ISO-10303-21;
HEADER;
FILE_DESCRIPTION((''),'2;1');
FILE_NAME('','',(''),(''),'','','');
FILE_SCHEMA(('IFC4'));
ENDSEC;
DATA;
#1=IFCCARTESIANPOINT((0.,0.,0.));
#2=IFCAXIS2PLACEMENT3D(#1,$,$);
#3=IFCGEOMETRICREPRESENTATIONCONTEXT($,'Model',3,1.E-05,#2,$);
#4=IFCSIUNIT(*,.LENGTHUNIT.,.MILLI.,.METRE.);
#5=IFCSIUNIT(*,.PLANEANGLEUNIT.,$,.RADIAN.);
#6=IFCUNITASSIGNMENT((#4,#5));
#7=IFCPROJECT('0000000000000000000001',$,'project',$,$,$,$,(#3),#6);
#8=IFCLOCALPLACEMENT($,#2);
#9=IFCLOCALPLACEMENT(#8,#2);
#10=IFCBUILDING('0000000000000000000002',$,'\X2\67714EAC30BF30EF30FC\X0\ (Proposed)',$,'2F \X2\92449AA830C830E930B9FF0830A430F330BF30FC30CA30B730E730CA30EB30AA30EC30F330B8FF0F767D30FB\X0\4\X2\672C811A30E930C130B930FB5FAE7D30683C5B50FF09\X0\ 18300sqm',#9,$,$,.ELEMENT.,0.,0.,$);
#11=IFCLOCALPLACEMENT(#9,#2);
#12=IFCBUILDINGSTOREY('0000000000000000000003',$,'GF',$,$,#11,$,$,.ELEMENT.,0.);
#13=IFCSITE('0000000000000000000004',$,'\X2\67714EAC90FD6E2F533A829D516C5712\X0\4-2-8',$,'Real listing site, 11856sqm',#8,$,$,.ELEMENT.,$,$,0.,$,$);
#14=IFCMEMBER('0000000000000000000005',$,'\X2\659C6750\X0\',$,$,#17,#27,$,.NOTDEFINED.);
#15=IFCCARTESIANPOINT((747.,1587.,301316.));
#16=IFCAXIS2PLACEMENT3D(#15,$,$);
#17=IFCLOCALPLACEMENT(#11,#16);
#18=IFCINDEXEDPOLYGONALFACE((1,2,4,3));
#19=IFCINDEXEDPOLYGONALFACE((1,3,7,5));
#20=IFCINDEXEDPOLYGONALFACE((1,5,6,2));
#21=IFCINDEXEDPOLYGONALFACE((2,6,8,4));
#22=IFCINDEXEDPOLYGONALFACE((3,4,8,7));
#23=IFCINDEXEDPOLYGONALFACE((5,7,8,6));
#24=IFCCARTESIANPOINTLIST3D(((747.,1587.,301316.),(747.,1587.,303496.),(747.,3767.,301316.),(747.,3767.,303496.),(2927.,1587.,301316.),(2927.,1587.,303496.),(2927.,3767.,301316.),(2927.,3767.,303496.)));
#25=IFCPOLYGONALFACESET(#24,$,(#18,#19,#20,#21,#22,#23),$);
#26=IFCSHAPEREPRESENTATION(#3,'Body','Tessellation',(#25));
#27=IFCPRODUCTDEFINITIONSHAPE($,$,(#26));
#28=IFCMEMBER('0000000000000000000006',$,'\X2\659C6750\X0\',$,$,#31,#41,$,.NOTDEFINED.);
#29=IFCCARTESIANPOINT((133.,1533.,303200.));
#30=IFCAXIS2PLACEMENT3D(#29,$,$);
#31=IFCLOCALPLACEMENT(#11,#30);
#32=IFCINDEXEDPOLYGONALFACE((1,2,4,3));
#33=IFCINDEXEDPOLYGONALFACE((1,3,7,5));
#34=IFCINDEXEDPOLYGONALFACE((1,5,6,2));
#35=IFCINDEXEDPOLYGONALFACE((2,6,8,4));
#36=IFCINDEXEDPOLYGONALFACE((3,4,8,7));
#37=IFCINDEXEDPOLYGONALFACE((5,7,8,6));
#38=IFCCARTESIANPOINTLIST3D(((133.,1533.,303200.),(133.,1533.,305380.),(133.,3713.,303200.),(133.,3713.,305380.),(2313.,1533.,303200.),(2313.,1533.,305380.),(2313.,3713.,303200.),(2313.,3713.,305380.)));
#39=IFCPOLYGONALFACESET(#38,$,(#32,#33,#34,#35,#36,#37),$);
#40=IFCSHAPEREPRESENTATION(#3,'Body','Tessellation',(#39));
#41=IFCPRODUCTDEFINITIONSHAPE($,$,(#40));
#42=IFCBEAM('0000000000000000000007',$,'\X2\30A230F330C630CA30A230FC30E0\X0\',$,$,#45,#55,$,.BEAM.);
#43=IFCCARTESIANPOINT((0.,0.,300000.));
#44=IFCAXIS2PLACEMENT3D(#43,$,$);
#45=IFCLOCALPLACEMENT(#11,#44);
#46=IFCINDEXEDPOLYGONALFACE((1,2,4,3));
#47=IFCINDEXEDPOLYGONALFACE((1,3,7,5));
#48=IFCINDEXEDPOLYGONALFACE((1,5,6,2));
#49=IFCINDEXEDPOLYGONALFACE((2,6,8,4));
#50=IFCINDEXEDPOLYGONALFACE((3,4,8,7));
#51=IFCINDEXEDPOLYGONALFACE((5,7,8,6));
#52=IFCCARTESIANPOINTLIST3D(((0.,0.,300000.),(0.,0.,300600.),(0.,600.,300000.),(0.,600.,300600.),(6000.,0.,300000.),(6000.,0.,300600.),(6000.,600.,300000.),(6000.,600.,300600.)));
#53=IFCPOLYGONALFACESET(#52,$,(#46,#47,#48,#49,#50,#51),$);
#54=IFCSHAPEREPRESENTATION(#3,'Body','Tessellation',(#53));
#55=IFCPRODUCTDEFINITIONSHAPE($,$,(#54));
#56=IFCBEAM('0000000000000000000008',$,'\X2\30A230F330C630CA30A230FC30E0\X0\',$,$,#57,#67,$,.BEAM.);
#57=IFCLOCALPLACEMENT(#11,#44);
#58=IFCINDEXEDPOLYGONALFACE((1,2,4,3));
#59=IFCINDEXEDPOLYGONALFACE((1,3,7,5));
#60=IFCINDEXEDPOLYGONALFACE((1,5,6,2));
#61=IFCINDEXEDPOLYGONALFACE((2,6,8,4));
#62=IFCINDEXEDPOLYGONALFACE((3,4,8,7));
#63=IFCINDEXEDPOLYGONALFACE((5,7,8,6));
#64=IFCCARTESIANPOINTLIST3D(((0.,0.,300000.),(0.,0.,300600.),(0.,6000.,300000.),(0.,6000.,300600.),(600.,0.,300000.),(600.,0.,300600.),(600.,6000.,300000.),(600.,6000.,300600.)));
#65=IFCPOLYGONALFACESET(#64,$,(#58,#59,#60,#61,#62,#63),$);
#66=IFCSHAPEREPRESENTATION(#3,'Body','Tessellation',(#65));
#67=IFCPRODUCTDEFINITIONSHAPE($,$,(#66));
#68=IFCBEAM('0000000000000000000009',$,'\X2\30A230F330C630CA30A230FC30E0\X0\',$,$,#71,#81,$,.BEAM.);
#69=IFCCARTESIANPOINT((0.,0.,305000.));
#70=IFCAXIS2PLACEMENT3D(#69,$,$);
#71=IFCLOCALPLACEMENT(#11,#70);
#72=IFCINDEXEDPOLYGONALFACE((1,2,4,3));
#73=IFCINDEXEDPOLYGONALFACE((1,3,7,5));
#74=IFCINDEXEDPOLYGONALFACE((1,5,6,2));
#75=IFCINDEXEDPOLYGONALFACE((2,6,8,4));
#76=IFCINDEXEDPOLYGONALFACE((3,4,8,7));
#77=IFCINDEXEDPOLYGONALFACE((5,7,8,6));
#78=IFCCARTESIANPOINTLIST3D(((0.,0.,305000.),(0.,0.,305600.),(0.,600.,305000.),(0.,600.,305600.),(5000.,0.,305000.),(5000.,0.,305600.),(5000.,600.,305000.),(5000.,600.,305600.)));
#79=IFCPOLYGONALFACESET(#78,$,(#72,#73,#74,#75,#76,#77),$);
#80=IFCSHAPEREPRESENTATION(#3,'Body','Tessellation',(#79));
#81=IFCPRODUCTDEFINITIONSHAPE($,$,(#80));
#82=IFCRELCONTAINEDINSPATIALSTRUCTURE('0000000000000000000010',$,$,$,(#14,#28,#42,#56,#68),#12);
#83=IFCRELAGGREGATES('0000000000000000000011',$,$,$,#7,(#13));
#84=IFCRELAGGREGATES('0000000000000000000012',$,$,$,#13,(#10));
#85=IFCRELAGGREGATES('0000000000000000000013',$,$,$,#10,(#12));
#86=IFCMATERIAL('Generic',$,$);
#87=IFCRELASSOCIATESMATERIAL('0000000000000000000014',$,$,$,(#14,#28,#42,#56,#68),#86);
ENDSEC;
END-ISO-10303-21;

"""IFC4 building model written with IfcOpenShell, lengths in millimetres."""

from ifc_helpers import new_model, si_unit, frame, frame_2d, origin, place, context, project, spatial, rectangle, extrude, material, element, save


model = new_model("IFC4")

# Units and contexts
model_context = context("Model", 3, precision=1e-05, world=origin())
ifc_project = project(units=[si_unit("LENGTHUNIT", "METRE", prefix="MILLI"), si_unit("PLANEANGLEUNIT", "RADIAN")], contexts=[model_context])

# Site, building, storey
site_placement = place(None, origin())
site = spatial("IfcSite", under=ifc_project, at=site_placement, Name="東京都港区芝公園4-2-8", ObjectType="Real listing site, 11856sqm", CompositionType="ELEMENT", RefElevation=0.0)
building_placement = place(site_placement, origin())
building = spatial("IfcBuilding", under=site, at=building_placement, Name="東京タワー (Proposed)", ObjectType="2F 鉄骨トラス（インターナショナルオレンジ／白・4本脚ラチス・微細格子） 18300sqm", CompositionType="ELEMENT", ElevationOfRefHeight=0.0, ElevationOfTerrain=0.0)
storey_placement = place(building_placement, origin())
storey = spatial("IfcBuildingStorey", under=building, at=storey_placement, Name="GF", CompositionType="ELEMENT", Elevation=0.0)

# Shared definitions
ifc_material = material(Name="Generic")

# Members
member_1_placement = place(storey_placement, frame((747.0, 1587.0, 301316.0)))
element("IfcMember", 1, at=member_1_placement, inside=storey, material=ifc_material, Name="斜材", PredefinedType="NOTDEFINED", context=model_context, shape_type="SweptSolid", body=[
    extrude(rectangle(XDim=2180.0, YDim=2180.0, at=frame_2d((1090.0, 1090.0))), frame((747.0, 1587.0, 301316.0)), (0.0, 0.0, 1.0), 2180.0),
])
member_2_placement = place(storey_placement, frame((133.0, 1533.0, 303200.0)))
element("IfcMember", 2, at=member_2_placement, inside=storey, material=ifc_material, Name="斜材", PredefinedType="NOTDEFINED", context=model_context, shape_type="SweptSolid", body=[
    extrude(rectangle(XDim=2180.0, YDim=2180.0, at=frame_2d((1090.0, 1090.0))), frame((133.0, 1533.0, 303200.0)), (0.0, 0.0, 1.0), 2180.0),
])

# Beams
beam_1_placement = place(storey_placement, frame((0.0, 0.0, 300000.0)))
element("IfcBeam", 3, at=beam_1_placement, inside=storey, material=ifc_material, Name="アンテナアーム", PredefinedType="BEAM", context=model_context, shape_type="SweptSolid", body=[
    extrude(rectangle(XDim=6000.0, YDim=600.0, at=frame_2d((3000.0, 300.0))), frame((0.0, 0.0, 300000.0)), (0.0, 0.0, 1.0), 600.0),
])
beam_2_placement = place(storey_placement, frame((0.0, 0.0, 300000.0)))
element("IfcBeam", 4, at=beam_2_placement, inside=storey, material=ifc_material, Name="アンテナアーム", PredefinedType="BEAM", context=model_context, shape_type="SweptSolid", body=[
    extrude(rectangle(XDim=600.0, YDim=6000.0, at=frame_2d((300.0, 3000.0))), frame((0.0, 0.0, 300000.0)), (0.0, 0.0, 1.0), 600.0),
])
beam_3_placement = place(storey_placement, frame((0.0, 0.0, 305000.0)))
element("IfcBeam", 5, at=beam_3_placement, inside=storey, material=ifc_material, Name="アンテナアーム", PredefinedType="BEAM", context=model_context, shape_type="SweptSolid", body=[
    extrude(rectangle(XDim=5000.0, YDim=600.0, at=frame_2d((2500.0, 300.0))), frame((0.0, 0.0, 305000.0)), (0.0, 0.0, 1.0), 600.0),
])

save(model, "model.ifc")
